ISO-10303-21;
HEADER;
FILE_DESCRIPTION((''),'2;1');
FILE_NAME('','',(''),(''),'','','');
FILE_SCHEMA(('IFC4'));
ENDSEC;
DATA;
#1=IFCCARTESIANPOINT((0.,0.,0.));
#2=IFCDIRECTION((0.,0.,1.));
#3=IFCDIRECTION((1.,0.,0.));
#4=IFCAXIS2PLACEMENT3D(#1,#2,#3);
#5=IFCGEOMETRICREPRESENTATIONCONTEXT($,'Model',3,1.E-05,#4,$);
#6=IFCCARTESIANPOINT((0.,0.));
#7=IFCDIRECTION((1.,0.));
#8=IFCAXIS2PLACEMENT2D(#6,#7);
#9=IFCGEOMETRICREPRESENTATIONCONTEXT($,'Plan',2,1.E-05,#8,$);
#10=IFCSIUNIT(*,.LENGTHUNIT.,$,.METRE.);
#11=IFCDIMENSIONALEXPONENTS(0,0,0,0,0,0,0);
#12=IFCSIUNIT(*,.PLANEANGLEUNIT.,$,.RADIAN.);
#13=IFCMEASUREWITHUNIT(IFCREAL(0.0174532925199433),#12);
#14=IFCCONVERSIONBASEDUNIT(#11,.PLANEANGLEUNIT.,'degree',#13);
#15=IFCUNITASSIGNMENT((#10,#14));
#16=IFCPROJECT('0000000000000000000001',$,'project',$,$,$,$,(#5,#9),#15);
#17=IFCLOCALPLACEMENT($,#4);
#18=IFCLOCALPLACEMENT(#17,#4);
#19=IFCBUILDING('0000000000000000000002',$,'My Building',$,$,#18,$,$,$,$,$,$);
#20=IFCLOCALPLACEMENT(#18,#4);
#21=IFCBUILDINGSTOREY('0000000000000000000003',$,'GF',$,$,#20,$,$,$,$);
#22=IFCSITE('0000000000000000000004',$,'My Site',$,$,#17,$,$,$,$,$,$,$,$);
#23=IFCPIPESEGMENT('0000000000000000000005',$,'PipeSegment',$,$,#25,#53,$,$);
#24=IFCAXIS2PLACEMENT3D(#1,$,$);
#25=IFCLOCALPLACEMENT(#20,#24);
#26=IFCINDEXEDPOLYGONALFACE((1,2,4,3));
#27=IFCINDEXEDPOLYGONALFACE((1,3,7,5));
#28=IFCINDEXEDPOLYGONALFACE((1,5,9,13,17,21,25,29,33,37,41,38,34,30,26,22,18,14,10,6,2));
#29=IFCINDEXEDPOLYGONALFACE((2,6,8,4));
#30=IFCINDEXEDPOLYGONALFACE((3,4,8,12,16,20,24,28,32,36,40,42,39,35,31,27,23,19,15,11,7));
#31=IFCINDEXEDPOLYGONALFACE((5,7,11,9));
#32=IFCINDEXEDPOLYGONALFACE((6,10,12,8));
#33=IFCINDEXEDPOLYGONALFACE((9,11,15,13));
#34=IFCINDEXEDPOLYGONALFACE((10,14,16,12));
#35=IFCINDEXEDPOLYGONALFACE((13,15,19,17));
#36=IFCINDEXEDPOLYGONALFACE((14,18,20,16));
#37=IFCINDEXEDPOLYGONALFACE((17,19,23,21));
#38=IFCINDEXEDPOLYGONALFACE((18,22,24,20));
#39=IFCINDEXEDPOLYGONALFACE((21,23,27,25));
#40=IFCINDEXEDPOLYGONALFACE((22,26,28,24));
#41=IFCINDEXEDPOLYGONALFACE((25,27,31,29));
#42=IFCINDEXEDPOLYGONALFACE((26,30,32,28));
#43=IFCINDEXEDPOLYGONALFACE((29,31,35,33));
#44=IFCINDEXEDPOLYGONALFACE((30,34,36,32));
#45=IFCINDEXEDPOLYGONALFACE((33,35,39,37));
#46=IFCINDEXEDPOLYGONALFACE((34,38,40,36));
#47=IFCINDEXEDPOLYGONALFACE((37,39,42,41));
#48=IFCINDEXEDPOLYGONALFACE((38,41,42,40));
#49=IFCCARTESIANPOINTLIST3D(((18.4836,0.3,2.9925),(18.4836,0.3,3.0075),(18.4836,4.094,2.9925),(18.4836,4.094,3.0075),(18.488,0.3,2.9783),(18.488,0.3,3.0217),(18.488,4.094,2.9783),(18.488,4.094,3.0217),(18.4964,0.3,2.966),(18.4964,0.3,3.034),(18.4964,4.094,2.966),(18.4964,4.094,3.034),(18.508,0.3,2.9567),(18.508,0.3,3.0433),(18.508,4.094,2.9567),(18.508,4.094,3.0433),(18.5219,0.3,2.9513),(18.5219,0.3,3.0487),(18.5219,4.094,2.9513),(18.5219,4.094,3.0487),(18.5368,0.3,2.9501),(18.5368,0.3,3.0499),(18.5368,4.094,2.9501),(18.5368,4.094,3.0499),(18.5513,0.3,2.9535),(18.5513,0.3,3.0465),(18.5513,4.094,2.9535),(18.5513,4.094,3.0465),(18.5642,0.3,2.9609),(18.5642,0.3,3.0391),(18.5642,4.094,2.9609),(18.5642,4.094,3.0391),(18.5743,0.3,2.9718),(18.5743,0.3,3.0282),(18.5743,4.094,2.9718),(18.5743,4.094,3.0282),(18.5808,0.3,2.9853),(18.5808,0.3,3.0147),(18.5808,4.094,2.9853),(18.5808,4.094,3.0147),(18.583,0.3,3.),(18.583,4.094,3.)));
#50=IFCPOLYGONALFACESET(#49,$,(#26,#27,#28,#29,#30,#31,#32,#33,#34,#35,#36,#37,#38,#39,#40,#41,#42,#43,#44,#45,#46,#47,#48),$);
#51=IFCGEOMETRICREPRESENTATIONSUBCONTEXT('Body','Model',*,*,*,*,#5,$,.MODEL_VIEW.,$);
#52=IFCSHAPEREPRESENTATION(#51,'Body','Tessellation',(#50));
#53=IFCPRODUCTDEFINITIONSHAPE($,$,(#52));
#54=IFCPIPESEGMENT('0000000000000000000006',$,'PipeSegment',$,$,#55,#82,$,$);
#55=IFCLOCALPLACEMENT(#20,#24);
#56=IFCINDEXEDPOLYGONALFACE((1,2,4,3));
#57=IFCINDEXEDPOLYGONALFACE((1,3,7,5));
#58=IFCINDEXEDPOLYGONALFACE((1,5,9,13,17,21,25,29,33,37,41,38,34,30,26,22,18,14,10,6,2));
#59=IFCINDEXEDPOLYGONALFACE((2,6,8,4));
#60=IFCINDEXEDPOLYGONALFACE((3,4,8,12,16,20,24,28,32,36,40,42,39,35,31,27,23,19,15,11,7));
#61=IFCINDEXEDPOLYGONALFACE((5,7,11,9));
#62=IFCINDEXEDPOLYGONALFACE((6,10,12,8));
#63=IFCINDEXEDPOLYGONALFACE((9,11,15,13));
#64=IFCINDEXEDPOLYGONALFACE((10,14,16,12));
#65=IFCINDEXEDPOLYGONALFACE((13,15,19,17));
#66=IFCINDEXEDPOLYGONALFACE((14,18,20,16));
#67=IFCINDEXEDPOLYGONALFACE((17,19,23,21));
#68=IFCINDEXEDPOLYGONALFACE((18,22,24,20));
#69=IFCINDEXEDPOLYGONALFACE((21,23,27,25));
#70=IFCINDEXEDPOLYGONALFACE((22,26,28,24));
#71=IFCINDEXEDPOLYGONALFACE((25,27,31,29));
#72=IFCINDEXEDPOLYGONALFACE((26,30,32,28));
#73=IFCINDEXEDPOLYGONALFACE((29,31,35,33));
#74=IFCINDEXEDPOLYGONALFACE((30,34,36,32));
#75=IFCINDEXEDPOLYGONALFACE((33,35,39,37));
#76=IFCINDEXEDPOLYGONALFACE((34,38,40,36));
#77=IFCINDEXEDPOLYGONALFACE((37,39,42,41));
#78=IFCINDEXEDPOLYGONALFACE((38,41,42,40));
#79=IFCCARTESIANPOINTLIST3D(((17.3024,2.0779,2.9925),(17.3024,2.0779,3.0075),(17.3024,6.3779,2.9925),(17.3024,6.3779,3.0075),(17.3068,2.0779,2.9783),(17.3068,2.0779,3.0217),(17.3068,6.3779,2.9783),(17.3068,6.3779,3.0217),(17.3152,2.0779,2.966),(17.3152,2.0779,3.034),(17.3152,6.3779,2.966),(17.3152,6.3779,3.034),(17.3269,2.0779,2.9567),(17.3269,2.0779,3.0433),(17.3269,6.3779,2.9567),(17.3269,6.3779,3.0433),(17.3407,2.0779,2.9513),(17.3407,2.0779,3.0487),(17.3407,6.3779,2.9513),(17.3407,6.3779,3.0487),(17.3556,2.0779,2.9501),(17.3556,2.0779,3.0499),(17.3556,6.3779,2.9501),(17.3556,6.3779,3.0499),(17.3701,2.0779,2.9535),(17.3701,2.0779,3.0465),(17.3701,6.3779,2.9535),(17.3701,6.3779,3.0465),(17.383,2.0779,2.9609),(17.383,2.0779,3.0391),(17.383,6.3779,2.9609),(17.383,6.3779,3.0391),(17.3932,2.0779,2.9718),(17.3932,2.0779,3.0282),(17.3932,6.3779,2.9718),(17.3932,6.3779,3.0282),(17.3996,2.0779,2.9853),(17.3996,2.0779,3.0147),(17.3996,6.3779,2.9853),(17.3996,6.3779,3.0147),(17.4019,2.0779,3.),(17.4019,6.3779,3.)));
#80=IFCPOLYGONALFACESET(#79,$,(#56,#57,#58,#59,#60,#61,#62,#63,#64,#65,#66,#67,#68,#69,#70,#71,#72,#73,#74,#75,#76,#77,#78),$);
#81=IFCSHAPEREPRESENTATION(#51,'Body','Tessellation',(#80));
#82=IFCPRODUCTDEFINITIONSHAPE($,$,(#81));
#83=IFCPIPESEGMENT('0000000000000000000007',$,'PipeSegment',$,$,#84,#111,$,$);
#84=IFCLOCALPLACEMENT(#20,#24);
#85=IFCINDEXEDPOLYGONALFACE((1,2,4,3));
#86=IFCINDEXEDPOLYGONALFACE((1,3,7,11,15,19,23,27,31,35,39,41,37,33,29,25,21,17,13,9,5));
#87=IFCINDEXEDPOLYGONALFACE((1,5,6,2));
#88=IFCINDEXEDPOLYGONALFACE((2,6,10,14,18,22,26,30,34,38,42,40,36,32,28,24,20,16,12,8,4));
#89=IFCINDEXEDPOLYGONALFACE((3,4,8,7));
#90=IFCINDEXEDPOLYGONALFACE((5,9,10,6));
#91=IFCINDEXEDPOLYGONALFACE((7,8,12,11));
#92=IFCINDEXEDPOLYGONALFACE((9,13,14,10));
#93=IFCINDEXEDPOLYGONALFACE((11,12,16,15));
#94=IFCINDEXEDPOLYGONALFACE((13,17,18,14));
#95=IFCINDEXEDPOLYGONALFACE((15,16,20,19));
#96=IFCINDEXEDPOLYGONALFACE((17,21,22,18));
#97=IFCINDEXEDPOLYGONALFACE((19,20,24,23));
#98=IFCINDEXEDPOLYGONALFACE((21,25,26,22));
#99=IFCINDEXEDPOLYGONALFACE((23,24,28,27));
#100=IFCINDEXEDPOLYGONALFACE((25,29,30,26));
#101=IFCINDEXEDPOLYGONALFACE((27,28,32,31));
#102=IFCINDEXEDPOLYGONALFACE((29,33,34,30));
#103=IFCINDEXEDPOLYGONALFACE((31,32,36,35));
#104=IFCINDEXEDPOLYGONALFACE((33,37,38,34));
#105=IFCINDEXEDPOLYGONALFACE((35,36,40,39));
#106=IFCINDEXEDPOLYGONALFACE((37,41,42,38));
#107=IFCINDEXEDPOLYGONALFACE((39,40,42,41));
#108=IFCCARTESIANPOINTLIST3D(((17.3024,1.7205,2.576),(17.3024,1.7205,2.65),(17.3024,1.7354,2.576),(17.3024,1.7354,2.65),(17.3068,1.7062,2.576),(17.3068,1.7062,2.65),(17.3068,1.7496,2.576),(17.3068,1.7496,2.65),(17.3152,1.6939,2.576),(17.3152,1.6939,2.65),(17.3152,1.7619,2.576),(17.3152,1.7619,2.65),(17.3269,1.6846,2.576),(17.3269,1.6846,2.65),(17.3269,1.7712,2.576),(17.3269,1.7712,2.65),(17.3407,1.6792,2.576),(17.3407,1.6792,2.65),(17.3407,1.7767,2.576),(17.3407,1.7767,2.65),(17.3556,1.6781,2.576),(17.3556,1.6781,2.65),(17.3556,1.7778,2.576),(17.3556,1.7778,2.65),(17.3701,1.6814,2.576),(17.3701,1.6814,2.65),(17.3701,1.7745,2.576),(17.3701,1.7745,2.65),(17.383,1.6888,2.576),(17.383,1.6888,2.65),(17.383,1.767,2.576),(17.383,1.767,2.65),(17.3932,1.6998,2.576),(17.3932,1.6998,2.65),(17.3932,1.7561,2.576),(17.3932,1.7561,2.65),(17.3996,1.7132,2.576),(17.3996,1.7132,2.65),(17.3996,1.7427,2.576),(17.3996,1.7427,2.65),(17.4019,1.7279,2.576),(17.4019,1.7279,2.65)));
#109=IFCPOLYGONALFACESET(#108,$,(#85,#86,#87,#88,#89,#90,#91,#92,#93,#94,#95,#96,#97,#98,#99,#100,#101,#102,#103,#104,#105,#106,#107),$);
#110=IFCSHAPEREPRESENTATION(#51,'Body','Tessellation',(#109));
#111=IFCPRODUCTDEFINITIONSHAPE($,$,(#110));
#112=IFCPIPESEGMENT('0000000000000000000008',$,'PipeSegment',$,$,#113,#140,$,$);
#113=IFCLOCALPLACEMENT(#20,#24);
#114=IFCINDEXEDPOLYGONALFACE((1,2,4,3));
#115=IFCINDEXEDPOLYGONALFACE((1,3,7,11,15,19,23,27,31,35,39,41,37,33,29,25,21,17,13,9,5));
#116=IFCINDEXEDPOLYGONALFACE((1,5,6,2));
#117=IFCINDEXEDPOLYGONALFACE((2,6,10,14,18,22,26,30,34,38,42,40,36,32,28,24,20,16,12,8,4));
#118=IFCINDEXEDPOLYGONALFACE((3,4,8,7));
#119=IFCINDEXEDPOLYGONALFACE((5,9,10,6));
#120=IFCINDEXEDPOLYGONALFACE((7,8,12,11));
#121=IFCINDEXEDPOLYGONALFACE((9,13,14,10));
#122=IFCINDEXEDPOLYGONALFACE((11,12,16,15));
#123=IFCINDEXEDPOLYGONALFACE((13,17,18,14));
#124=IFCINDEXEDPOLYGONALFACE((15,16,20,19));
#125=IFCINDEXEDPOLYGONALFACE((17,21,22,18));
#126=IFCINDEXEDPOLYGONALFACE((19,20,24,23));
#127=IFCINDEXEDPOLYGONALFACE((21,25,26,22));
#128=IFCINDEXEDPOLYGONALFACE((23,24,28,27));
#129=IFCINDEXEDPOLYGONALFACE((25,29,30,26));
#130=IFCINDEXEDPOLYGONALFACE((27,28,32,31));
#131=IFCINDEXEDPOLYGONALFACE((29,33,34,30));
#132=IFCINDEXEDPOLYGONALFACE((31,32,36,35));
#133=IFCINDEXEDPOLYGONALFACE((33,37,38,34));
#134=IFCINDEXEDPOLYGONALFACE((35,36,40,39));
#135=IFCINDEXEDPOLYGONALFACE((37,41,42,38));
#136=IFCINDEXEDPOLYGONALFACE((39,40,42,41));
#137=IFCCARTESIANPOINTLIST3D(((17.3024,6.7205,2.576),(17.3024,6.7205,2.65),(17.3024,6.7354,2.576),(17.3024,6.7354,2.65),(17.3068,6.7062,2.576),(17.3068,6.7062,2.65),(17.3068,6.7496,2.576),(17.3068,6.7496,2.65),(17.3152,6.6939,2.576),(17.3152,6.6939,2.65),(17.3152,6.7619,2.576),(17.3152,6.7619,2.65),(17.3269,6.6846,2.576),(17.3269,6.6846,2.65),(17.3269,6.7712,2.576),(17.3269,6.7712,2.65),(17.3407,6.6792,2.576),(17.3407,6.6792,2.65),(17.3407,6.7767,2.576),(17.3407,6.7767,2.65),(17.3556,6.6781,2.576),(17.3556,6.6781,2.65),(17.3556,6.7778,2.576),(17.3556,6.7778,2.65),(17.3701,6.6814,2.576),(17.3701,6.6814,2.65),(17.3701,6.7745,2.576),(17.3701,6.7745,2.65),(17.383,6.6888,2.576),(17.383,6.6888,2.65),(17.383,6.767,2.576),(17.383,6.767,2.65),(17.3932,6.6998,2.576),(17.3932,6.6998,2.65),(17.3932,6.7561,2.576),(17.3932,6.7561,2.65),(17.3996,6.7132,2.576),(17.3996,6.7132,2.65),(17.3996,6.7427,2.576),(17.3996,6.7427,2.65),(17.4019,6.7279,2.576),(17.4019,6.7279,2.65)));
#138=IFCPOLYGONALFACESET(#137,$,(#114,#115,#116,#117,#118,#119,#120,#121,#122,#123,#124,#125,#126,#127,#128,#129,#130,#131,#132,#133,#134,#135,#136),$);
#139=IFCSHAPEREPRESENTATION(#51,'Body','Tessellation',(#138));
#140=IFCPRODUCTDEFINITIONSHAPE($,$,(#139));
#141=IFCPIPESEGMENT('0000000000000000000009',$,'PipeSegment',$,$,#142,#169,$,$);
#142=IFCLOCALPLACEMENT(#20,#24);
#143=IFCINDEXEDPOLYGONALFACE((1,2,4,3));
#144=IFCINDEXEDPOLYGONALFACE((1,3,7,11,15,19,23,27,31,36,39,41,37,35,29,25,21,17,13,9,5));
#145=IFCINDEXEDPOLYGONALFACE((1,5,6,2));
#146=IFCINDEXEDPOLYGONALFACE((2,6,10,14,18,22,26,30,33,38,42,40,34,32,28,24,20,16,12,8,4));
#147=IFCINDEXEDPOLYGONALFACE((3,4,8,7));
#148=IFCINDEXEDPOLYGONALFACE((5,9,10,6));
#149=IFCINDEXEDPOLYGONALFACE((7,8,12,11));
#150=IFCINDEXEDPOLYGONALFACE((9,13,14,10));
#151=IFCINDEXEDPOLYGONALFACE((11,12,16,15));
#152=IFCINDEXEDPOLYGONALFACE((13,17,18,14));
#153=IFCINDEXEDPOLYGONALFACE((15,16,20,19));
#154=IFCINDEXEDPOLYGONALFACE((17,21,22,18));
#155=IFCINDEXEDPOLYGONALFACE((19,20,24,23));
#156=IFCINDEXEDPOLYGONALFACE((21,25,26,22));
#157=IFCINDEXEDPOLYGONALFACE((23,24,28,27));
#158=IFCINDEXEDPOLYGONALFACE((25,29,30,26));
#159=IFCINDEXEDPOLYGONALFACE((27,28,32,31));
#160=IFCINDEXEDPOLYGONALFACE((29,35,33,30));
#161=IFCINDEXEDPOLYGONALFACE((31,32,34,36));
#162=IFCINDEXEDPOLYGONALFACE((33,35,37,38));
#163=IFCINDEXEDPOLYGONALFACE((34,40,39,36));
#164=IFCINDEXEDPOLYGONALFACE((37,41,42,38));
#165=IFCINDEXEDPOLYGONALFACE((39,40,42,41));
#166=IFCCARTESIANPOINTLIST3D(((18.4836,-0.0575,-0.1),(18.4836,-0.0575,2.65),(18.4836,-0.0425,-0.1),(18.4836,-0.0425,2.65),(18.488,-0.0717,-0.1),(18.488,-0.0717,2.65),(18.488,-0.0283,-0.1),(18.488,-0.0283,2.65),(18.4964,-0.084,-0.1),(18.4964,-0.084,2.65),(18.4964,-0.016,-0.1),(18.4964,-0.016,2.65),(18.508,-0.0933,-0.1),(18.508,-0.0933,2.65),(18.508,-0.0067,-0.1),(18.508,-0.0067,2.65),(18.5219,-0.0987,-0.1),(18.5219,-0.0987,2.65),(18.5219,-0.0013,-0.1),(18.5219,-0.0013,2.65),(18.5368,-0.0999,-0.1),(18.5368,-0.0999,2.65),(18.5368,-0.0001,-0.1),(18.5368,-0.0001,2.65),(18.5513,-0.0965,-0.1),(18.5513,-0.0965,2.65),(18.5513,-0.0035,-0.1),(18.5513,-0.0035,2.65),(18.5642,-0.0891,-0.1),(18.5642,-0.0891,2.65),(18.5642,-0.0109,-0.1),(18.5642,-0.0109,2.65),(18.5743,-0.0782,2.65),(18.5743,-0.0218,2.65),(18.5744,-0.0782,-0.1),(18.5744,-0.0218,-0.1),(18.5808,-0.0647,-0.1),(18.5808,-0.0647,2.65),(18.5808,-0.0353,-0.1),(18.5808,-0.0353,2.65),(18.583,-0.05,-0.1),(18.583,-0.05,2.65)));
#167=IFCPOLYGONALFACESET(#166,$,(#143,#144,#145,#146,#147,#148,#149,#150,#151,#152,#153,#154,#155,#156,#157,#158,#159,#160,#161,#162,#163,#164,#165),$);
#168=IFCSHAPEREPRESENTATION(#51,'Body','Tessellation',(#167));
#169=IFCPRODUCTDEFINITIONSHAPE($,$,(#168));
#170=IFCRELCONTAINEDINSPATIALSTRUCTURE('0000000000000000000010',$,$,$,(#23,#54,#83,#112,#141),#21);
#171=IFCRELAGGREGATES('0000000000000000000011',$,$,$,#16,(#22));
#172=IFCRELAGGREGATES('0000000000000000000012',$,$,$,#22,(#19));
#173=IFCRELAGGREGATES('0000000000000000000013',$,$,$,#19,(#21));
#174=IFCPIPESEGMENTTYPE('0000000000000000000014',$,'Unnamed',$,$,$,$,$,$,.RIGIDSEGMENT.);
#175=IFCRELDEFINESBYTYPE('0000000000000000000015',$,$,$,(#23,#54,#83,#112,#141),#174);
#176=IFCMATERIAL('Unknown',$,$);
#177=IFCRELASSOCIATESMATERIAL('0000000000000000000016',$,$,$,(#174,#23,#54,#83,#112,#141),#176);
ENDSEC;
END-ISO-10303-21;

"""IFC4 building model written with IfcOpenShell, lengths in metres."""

from ifc_helpers import new_model, entity, si_unit, converted_unit, frame, origin_with_axes, origin_2d_with_axis, place, context, subcontext, project, spatial, circle, extrude, material, material_profile, profile_set, profile_usage, type_object, element, save


model = new_model("IFC4")

# Units and contexts
model_context = context("Model", 3, precision=1e-05, world=origin_with_axes())
plan_context = context("Plan", 2, precision=1e-05, world=origin_2d_with_axis())
body_context_1 = subcontext(model_context, "Body", "Model", "MODEL_VIEW")
ifc_project = project(units=[si_unit("LENGTHUNIT", "METRE"), converted_unit("PLANEANGLEUNIT", "degree", entity("IfcReal", 0.0174532925199433), si_unit("PLANEANGLEUNIT", "RADIAN"), dimensions=[0, 0, 0, 0, 0, 0, 0])], contexts=[model_context, plan_context])

# Site, building, storey
site_placement = place(None, origin_with_axes())
site = spatial("IfcSite", under=ifc_project, at=site_placement, Name="My Site")
building_placement = place(site_placement, origin_with_axes())
building = spatial("IfcBuilding", under=site, at=building_placement, Name="My Building")
storey_placement = place(building_placement, origin_with_axes())
storey = spatial("IfcBuildingStorey", under=building, at=storey_placement, Name="GF")

# Shared definitions
ifc_material = material(Name="Unknown")

# Pipe segments
ifc_material_profile = material_profile(ifc_material, circle(Radius=0.05))
ifc_profile_set = profile_set([ifc_material_profile])
ifc_profile_usage_1 = profile_usage(ifc_profile_set, cardinal=5)
pipe_segment_type = type_object("IfcPipeSegmentType", Name="Unnamed", PredefinedType="RIGIDSEGMENT", material=ifc_profile_set)
pipe_segment_1_placement = place(storey_placement, frame((18.533, 4.094, 3.0), z_axis=(0.0, -1.0, 0.0), x_axis=(1.0, 0.0, 0.0)))
element("IfcPipeSegment", 1, at=pipe_segment_1_placement, inside=storey, type_object=pipe_segment_type, material=ifc_profile_usage_1, Name="PipeSegment", context=body_context_1, shape_type="SweptSolid", body=[
    extrude(circle(Radius=0.05), origin_with_axes(), (0.0, 0.0, 1.0), 3.794),
])
ifc_profile_usage_2 = profile_usage(ifc_profile_set, cardinal=5)
pipe_segment_2_placement = place(storey_placement, frame((17.3519, 6.3779, 3.0), z_axis=(0.0, -1.0, 0.0), x_axis=(1.0, 0.0, 0.0)))
element("IfcPipeSegment", 2, at=pipe_segment_2_placement, inside=storey, type_object=pipe_segment_type, material=ifc_profile_usage_2, Name="PipeSegment", context=body_context_1, shape_type="SweptSolid", body=[
    extrude(circle(Radius=0.05), origin_with_axes(), (0.0, 0.0, 1.0), 4.3),
])
ifc_profile_usage_3 = profile_usage(ifc_profile_set, cardinal=5)
pipe_segment_3_placement = place(storey_placement, frame((17.3519, 1.7279, 2.576), z_axis=(0.0, 0.0, 1.0), x_axis=(1.0, 0.0, 0.0)))
element("IfcPipeSegment", 3, at=pipe_segment_3_placement, inside=storey, type_object=pipe_segment_type, material=ifc_profile_usage_3, Name="PipeSegment", context=body_context_1, shape_type="SweptSolid", body=[
    extrude(circle(Radius=0.05), origin_with_axes(), (0.0, 0.0, 1.0), 0.074),
])
ifc_profile_usage_4 = profile_usage(ifc_profile_set, cardinal=5)
pipe_segment_4_placement = place(storey_placement, frame((17.3519, 6.7279, 2.576), z_axis=(0.0, 0.0, 1.0), x_axis=(1.0, 0.0, 0.0)))
element("IfcPipeSegment", 4, at=pipe_segment_4_placement, inside=storey, type_object=pipe_segment_type, material=ifc_profile_usage_4, Name="PipeSegment", context=body_context_1, shape_type="SweptSolid", body=[
    extrude(circle(Radius=0.05), origin_with_axes(), (0.0, 0.0, 1.0), 0.074),
])
ifc_profile_usage_5 = profile_usage(ifc_profile_set, cardinal=5)
pipe_segment_5_placement = place(storey_placement, frame((18.533, -0.05, -0.1), z_axis=(-0.000004, 0.0, 1.0), x_axis=(1.0, 0.0, 0.000004)))
element("IfcPipeSegment", 5, at=pipe_segment_5_placement, inside=storey, type_object=pipe_segment_type, material=ifc_profile_usage_5, Name="PipeSegment", context=body_context_1, shape_type="SweptSolid", body=[
    extrude(circle(Radius=0.05), origin_with_axes(), (0.0, 0.0, 1.0), 2.75),
])

save(model, "model.ifc")
